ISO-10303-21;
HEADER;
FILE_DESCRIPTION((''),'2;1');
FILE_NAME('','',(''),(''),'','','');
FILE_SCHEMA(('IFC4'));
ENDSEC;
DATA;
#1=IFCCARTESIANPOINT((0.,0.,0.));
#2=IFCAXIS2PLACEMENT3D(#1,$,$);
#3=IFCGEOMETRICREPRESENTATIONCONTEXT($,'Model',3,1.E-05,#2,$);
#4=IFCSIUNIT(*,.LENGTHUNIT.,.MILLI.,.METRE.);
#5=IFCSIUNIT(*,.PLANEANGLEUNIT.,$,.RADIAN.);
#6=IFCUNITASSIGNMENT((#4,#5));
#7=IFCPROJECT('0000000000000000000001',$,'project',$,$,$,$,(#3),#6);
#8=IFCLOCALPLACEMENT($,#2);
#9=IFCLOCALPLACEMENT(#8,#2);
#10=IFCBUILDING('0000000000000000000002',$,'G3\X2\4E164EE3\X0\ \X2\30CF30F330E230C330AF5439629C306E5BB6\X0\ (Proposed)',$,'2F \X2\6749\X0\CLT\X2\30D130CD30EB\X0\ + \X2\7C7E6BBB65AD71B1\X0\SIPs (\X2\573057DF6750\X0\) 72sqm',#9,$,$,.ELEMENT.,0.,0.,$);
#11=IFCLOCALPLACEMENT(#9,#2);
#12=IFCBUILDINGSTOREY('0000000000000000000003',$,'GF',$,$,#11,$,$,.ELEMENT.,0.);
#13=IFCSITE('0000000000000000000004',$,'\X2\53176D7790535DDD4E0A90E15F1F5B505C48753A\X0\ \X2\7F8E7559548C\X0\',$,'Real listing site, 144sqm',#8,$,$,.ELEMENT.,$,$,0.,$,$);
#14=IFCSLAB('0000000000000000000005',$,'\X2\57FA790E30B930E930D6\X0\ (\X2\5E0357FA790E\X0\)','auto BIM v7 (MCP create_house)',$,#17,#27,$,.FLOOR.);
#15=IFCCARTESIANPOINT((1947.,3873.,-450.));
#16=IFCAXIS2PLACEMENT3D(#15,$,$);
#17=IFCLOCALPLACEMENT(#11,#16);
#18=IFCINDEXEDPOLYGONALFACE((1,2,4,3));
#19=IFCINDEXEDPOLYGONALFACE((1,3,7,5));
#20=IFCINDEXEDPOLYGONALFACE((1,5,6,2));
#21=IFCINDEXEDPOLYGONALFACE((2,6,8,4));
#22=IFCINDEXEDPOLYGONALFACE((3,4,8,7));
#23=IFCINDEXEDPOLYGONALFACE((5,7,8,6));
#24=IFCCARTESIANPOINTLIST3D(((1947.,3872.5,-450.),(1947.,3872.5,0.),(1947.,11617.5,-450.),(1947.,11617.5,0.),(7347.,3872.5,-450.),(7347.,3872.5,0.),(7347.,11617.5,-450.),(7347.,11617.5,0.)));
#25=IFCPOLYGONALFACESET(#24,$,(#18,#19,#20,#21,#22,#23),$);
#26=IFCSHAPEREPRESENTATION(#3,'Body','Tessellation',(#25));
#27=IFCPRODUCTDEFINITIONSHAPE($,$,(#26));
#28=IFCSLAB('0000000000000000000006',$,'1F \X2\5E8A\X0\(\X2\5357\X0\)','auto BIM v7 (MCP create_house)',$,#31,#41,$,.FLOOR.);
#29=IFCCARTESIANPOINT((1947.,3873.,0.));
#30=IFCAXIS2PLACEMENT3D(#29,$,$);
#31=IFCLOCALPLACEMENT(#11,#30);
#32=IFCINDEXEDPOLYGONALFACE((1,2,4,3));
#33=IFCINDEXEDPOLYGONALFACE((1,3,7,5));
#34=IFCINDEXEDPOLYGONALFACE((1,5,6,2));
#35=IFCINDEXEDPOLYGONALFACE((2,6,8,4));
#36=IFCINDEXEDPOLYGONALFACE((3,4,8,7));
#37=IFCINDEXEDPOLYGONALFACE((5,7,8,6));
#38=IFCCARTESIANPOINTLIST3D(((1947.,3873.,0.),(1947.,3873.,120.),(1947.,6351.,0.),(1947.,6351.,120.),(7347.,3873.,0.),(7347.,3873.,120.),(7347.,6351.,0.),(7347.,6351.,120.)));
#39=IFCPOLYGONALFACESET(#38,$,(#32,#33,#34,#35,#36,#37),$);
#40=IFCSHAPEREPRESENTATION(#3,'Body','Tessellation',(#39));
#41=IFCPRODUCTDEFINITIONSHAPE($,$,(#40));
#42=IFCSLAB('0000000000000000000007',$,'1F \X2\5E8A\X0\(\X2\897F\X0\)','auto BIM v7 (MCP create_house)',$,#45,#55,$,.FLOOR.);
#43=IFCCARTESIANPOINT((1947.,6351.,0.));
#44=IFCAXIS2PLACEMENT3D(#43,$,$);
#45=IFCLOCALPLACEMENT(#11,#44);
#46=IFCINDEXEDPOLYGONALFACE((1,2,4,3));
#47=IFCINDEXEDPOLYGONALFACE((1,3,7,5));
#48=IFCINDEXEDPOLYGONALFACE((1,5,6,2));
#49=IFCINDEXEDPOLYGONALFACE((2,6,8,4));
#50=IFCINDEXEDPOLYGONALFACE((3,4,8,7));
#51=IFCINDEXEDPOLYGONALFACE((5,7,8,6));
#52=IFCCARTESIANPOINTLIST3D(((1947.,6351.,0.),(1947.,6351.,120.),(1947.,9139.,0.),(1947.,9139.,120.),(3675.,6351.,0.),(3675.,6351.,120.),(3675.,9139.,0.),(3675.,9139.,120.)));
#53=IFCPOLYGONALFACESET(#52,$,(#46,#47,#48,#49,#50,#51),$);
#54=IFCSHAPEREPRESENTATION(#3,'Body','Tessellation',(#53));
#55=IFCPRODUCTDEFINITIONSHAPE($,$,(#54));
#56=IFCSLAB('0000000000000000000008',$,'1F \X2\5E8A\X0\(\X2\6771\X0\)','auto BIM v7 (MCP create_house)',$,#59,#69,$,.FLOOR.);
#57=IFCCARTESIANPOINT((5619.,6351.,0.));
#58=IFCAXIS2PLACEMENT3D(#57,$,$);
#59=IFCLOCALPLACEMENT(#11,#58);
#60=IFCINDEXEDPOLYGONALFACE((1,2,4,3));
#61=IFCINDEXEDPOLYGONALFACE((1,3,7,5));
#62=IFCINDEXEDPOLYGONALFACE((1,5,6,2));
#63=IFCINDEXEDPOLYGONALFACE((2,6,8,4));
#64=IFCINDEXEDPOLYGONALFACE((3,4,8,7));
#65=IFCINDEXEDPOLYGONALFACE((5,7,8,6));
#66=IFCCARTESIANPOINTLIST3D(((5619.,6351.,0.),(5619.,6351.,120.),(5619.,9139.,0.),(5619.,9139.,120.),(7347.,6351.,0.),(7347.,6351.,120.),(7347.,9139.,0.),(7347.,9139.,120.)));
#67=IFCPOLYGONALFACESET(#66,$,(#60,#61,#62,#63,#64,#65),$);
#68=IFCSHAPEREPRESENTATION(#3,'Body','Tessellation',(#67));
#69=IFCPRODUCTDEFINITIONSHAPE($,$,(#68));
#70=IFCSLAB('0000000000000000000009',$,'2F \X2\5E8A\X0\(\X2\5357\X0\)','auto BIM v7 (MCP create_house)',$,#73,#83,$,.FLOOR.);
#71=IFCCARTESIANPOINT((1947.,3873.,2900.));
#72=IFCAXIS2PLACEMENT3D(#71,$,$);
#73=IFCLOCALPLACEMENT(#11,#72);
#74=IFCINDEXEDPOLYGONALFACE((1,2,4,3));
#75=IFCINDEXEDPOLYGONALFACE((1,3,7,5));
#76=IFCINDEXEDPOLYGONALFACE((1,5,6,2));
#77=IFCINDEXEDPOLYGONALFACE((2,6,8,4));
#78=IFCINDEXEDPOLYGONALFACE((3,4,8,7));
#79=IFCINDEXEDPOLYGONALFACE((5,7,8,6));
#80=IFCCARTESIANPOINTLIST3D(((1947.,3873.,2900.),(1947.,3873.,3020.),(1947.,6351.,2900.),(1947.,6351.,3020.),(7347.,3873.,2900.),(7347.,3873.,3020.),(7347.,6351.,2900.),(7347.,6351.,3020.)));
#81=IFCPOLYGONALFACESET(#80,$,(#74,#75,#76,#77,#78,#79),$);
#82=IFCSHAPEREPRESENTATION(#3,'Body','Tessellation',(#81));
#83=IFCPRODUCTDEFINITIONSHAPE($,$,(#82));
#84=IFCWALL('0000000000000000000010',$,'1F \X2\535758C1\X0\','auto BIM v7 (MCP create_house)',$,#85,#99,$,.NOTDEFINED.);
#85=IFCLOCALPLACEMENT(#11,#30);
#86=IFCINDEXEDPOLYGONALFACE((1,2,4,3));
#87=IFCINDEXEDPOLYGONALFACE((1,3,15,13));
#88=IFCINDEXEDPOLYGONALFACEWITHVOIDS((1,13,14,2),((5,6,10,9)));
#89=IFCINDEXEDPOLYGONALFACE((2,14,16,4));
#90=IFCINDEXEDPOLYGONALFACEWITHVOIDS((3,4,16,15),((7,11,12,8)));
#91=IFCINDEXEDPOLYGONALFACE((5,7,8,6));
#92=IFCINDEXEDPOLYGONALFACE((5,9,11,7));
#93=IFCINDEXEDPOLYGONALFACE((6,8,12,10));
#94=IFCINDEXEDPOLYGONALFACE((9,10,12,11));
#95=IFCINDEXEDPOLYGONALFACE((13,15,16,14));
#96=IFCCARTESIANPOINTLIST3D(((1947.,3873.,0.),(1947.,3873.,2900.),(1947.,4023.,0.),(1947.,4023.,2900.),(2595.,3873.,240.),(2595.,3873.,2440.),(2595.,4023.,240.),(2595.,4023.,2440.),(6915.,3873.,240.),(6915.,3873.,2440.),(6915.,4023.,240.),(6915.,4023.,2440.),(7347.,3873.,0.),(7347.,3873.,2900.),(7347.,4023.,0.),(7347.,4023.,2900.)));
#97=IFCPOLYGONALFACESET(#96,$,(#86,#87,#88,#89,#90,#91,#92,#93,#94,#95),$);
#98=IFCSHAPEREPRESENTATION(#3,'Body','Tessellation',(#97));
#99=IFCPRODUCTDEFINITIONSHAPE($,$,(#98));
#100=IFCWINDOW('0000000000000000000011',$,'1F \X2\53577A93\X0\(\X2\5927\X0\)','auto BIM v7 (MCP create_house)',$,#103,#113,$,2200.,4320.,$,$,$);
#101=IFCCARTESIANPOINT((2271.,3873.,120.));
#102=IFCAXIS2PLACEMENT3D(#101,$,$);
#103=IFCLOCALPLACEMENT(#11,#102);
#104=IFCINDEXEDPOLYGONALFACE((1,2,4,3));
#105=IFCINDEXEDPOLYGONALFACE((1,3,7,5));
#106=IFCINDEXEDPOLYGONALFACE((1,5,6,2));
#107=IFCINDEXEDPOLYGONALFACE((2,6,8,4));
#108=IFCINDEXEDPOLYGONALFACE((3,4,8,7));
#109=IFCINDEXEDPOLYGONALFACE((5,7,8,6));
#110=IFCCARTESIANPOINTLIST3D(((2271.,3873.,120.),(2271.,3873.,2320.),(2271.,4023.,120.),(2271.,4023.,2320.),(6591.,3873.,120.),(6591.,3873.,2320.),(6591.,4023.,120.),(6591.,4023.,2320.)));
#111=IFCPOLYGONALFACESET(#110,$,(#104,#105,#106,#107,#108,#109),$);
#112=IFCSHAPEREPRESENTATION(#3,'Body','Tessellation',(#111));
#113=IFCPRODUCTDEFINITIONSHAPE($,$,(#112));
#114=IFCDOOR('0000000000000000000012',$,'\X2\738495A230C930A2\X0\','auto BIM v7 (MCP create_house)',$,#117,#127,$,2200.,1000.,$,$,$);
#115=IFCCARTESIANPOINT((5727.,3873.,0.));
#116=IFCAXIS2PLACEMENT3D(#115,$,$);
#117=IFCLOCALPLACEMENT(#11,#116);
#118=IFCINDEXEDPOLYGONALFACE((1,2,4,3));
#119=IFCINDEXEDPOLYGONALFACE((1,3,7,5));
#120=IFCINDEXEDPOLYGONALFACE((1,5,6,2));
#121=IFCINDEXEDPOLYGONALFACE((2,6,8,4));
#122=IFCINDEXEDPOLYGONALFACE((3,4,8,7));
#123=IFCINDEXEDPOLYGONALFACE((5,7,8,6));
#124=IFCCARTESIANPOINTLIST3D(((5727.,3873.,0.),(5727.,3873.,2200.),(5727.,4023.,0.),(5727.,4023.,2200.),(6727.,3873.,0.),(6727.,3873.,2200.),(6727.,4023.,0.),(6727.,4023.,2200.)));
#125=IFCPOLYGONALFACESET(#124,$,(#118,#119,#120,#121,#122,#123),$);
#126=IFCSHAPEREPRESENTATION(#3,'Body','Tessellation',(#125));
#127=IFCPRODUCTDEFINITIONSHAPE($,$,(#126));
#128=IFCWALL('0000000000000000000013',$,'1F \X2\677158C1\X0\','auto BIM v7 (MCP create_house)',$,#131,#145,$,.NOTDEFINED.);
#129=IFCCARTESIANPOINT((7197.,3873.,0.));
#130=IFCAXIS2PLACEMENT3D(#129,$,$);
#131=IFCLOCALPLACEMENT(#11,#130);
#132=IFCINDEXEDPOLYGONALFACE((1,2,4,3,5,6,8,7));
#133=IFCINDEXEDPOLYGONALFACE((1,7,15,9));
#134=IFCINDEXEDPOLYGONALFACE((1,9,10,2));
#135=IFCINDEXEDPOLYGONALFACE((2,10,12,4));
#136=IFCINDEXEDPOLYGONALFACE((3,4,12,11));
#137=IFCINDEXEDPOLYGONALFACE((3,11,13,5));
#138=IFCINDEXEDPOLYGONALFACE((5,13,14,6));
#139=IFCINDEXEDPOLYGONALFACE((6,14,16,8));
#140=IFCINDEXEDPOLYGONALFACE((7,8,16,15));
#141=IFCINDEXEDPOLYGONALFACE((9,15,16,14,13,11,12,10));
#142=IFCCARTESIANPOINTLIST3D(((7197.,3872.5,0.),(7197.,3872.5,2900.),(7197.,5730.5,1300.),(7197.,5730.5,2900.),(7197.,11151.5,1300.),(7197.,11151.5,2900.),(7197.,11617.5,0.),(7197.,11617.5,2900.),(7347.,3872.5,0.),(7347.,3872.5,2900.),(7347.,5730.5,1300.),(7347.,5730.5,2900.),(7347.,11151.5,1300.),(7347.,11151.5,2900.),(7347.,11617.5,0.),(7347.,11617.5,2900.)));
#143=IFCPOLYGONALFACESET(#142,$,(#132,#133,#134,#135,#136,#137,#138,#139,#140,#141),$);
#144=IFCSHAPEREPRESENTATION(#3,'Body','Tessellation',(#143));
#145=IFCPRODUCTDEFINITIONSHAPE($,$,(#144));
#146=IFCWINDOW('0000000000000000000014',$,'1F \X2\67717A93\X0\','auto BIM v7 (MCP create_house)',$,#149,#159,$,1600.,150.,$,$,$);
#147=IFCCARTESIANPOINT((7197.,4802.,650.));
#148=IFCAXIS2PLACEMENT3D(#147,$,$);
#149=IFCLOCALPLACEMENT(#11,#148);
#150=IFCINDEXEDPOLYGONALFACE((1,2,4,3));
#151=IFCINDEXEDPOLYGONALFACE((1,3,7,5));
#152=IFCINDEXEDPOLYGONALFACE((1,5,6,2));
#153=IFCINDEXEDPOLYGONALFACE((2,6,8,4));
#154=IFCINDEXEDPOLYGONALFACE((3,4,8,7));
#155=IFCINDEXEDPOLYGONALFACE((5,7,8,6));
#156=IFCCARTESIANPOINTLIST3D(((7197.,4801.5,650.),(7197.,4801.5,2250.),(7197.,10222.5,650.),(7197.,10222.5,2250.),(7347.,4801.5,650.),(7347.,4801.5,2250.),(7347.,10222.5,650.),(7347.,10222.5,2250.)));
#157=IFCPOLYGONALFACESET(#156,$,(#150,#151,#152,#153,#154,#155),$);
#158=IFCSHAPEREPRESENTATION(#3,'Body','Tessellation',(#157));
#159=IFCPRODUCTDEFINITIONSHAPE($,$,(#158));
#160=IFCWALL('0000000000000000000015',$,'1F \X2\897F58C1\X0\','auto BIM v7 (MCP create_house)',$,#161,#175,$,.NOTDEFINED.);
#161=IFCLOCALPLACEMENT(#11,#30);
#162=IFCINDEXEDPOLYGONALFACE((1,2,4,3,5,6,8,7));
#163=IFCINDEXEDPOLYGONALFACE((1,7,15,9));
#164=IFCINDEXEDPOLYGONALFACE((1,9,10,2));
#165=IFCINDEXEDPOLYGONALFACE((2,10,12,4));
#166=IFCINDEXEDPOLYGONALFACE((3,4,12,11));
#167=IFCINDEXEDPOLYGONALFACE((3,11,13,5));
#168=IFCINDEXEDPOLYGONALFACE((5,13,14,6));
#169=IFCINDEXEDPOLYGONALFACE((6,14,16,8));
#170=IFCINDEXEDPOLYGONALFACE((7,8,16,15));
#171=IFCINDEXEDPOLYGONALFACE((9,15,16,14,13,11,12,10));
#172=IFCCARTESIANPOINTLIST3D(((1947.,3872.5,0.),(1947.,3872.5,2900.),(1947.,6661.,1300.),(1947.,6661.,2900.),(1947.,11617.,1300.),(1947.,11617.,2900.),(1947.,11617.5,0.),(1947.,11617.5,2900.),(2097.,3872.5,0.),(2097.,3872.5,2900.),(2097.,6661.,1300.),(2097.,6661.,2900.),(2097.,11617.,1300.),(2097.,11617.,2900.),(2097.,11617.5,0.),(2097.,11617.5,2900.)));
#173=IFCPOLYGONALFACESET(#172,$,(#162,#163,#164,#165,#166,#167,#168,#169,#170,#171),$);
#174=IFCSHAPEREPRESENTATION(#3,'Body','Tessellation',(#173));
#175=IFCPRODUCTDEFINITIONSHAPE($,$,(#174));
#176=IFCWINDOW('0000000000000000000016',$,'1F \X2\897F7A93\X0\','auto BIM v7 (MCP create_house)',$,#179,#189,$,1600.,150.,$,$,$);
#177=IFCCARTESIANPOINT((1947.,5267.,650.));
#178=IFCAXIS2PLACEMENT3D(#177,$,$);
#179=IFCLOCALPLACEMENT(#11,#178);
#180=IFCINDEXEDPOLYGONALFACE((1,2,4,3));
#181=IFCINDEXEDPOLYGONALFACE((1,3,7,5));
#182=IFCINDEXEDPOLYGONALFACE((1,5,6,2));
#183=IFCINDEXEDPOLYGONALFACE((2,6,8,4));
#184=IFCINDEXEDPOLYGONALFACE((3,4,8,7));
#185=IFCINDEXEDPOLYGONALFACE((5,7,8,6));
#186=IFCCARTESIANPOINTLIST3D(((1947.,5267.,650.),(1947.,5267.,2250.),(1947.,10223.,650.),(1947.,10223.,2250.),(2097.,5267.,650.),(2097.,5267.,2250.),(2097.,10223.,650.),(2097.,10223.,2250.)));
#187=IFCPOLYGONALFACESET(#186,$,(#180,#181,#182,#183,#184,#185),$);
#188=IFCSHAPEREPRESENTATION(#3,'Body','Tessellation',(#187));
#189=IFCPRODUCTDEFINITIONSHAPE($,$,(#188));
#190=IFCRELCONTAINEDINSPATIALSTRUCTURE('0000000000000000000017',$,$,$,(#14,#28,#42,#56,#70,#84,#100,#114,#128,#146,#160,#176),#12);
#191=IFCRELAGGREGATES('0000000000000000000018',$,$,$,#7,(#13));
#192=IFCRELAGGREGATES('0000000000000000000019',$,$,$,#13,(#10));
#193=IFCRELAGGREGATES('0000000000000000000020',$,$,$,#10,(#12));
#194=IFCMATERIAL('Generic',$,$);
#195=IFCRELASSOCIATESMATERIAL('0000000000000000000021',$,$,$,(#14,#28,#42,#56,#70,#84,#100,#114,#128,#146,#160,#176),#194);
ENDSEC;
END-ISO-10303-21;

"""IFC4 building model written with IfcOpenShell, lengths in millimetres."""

from ifc_helpers import new_model, si_unit, frame, frame_2d, origin, place, context, project, spatial, rectangle, extrude, material, element, fill, save


model = new_model("IFC4")

# Units and contexts
model_context = context("Model", 3, precision=1e-05, world=origin())
ifc_project = project(units=[si_unit("LENGTHUNIT", "METRE", prefix="MILLI"), si_unit("PLANEANGLEUNIT", "RADIAN")], contexts=[model_context])

# Site, building, storey
site_placement = place(None, origin())
site = spatial("IfcSite", under=ifc_project, at=site_placement, Name="北海道川上郡弟子屈町 美留和", ObjectType="Real listing site, 144sqm", CompositionType="ELEMENT", RefElevation=0.0)
building_placement = place(site_placement, origin())
building = spatial("IfcBuilding", under=site, at=building_placement, Name="G3世代 ハンモック吹抜の家 (Proposed)", ObjectType="2F 杉CLTパネル + 籾殻断熱SIPs (地域材) 72sqm", CompositionType="ELEMENT", ElevationOfRefHeight=0.0, ElevationOfTerrain=0.0)
storey_placement = place(building_placement, origin())
storey = spatial("IfcBuildingStorey", under=building, at=storey_placement, Name="GF", CompositionType="ELEMENT", Elevation=0.0)

# Slabs
ifc_material = material(Name="Generic")
slab_1_placement = place(storey_placement, frame((1947.0, 3873.0, -450.0)))
element("IfcSlab", 1, at=slab_1_placement, inside=storey, material=ifc_material, Name="基礎スラブ (布基礎)", Description="auto BIM v7 (MCP create_house)", PredefinedType="FLOOR", context=model_context, shape_type="SweptSolid", body=[
    extrude(rectangle(XDim=5400.0, YDim=7745.0, at=frame_2d((2700.0, 3872.0))), frame((1947.0, 3873.0, -450.0)), (0.0, 0.0, 1.0), 450.0),
])
slab_2_placement = place(storey_placement, frame((1947.0, 3873.0, 0.0)))
element("IfcSlab", 2, at=slab_2_placement, inside=storey, material=ifc_material, Name="1F 床(南)", Description="auto BIM v7 (MCP create_house)", PredefinedType="FLOOR", context=model_context, shape_type="SweptSolid", body=[
    extrude(rectangle(XDim=5400.0, YDim=2478.0, at=frame_2d((2700.0, 1239.0))), frame((1947.0, 3873.0, 0.0)), (0.0, 0.0, 1.0), 120.0),
])
slab_3_placement = place(storey_placement, frame((1947.0, 6351.0, 0.0)))
element("IfcSlab", 3, at=slab_3_placement, inside=storey, material=ifc_material, Name="1F 床(西)", Description="auto BIM v7 (MCP create_house)", PredefinedType="FLOOR", context=model_context, shape_type="SweptSolid", body=[
    extrude(rectangle(XDim=1728.0, YDim=2788.0, at=frame_2d((864.0, 1394.0))), frame((1947.0, 6351.0, 0.0)), (0.0, 0.0, 1.0), 120.0),
])
slab_4_placement = place(storey_placement, frame((5619.0, 6351.0, 0.0)))
element("IfcSlab", 4, at=slab_4_placement, inside=storey, material=ifc_material, Name="1F 床(東)", Description="auto BIM v7 (MCP create_house)", PredefinedType="FLOOR", context=model_context, shape_type="SweptSolid", body=[
    extrude(rectangle(XDim=1728.0, YDim=2788.0, at=frame_2d((864.0, 1394.0))), frame((5619.0, 6351.0, 0.0)), (0.0, 0.0, 1.0), 120.0),
])
slab_5_placement = place(storey_placement, frame((1947.0, 3873.0, 2900.0)))
element("IfcSlab", 5, at=slab_5_placement, inside=storey, material=ifc_material, Name="2F 床(南)", Description="auto BIM v7 (MCP create_house)", PredefinedType="FLOOR", context=model_context, shape_type="SweptSolid", body=[
    extrude(rectangle(XDim=5400.0, YDim=2478.0, at=frame_2d((2700.0, 1239.0))), frame((1947.0, 3873.0, 2900.0)), (0.0, 0.0, 1.0), 120.0),
])

# Wall, openings, window, door
wall_1_placement = place(storey_placement, frame((1947.0, 3873.0, 0.0)))
wall_1 = element("IfcWall", 6, at=wall_1_placement, inside=storey, material=ifc_material, Name="1F 南壁", Description="auto BIM v7 (MCP create_house)", PredefinedType="NOTDEFINED", context=model_context, shape_type="SweptSolid", body=[
    extrude(rectangle(XDim=5400.0, YDim=150.0, at=frame_2d((2700.0, 75.0))), frame((1947.0, 3873.0, 0.0)), (0.0, 0.0, 1.0), 2900.0),
])
opening_1_placement = place(storey_placement, frame((2271.0, 3873.0, 120.0)))
opening_1 = element("IfcOpeningElement", 7, at=opening_1_placement, cuts=wall_1, PredefinedType="NOTDEFINED", context=model_context, shape_type="SweptSolid", body=[
    extrude(rectangle(XDim=4320.0, YDim=150.0, at=frame_2d((2160.0, 75.0))), frame((2271.0, 3873.0, 120.0)), (0.0, 0.0, 1.0), 2200.0),
])
opening_2_placement = place(storey_placement, frame((5727.0, 3873.0, 0.0)))
opening_2 = element("IfcOpeningElement", 8, at=opening_2_placement, cuts=wall_1, PredefinedType="NOTDEFINED", context=model_context, shape_type="SweptSolid", body=[
    extrude(rectangle(XDim=1000.0, YDim=150.0, at=frame_2d((500.0, 75.0))), frame((5727.0, 3873.0, 0.0)), (0.0, 0.0, 1.0), 2200.0),
])
window_1_placement = place(storey_placement, frame((2271.0, 3873.0, 120.0)))
window_1 = element("IfcWindow", 9, at=window_1_placement, inside=storey, material=ifc_material, Name="1F 南窓(大)", Description="auto BIM v7 (MCP create_house)", OverallHeight=2200.0, OverallWidth=4320.0, context=model_context, shape_type="SweptSolid", body=[
    extrude(rectangle(XDim=4320.0, YDim=150.0, at=frame_2d((2160.0, 75.0))), frame((2271.0, 3873.0, 120.0)), (0.0, 0.0, 1.0), 2200.0),
])
fill(opening_1, window_1)
door_placement = place(storey_placement, frame((5727.0, 3873.0, 0.0)))
door = element("IfcDoor", 10, at=door_placement, inside=storey, material=ifc_material, Name="玄関ドア", Description="auto BIM v7 (MCP create_house)", OverallHeight=2200.0, OverallWidth=1000.0, context=model_context, shape_type="SweptSolid", body=[
    extrude(rectangle(XDim=1000.0, YDim=150.0, at=frame_2d((500.0, 75.0))), frame((5727.0, 3873.0, 0.0)), (0.0, 0.0, 1.0), 2200.0),
])
fill(opening_2, door)

# Walls, openings, windows
wall_2_placement = place(storey_placement, frame((7197.0, 3873.0, 0.0)))
wall_2 = element("IfcWall", 11, at=wall_2_placement, inside=storey, material=ifc_material, Name="1F 東壁", Description="auto BIM v7 (MCP create_house)", PredefinedType="NOTDEFINED", context=model_context, shape_type="SweptSolid", body=[
    extrude(rectangle(XDim=150.0, YDim=7745.0, at=frame_2d((75.0, 3872.0))), frame((7197.0, 3873.0, 0.0)), (0.0, 0.0, 1.0), 2900.0),
])
opening_3_placement = place(storey_placement, frame((7197.0, 4802.0, 650.0)))
opening_3 = element("IfcOpeningElement", 12, at=opening_3_placement, cuts=wall_2, PredefinedType="NOTDEFINED", context=model_context, shape_type="SweptSolid", body=[
    extrude(rectangle(XDim=150.0, YDim=5421.0, at=frame_2d((75.0, 2710.0))), frame((7197.0, 4802.0, 650.0)), (0.0, 0.0, 1.0), 1600.0),
])
window_2_placement = place(storey_placement, frame((7197.0, 4802.0, 650.0)))
window_2 = element("IfcWindow", 13, at=window_2_placement, inside=storey, material=ifc_material, Name="1F 東窓", Description="auto BIM v7 (MCP create_house)", OverallHeight=1600.0, OverallWidth=150.0, context=model_context, shape_type="SweptSolid", body=[
    extrude(rectangle(XDim=150.0, YDim=5421.0, at=frame_2d((75.0, 2710.0))), frame((7197.0, 4802.0, 650.0)), (0.0, 0.0, 1.0), 1600.0),
])
fill(opening_3, window_2)
wall_3_placement = place(storey_placement, frame((1947.0, 3873.0, 0.0)))
wall_3 = element("IfcWall", 14, at=wall_3_placement, inside=storey, material=ifc_material, Name="1F 西壁", Description="auto BIM v7 (MCP create_house)", PredefinedType="NOTDEFINED", context=model_context, shape_type="SweptSolid", body=[
    extrude(rectangle(XDim=150.0, YDim=7745.0, at=frame_2d((75.0, 3872.0))), frame((1947.0, 3873.0, 0.0)), (0.0, 0.0, 1.0), 2900.0),
])
opening_4_placement = place(storey_placement, frame((1947.0, 5267.0, 650.0)))
opening_4 = element("IfcOpeningElement", 15, at=opening_4_placement, cuts=wall_3, PredefinedType="NOTDEFINED", context=model_context, shape_type="SweptSolid", body=[
    extrude(rectangle(XDim=150.0, YDim=4956.0, at=frame_2d((75.0, 2478.0))), frame((1947.0, 5267.0, 650.0)), (0.0, 0.0, 1.0), 1600.0),
])
window_3_placement = place(storey_placement, frame((1947.0, 5267.0, 650.0)))
window_3 = element("IfcWindow", 16, at=window_3_placement, inside=storey, material=ifc_material, Name="1F 西窓", Description="auto BIM v7 (MCP create_house)", OverallHeight=1600.0, OverallWidth=150.0, context=model_context, shape_type="SweptSolid", body=[
    extrude(rectangle(XDim=150.0, YDim=4956.0, at=frame_2d((75.0, 2478.0))), frame((1947.0, 5267.0, 650.0)), (0.0, 0.0, 1.0), 1600.0),
])
fill(opening_4, window_3)

save(model, "model.ifc")
